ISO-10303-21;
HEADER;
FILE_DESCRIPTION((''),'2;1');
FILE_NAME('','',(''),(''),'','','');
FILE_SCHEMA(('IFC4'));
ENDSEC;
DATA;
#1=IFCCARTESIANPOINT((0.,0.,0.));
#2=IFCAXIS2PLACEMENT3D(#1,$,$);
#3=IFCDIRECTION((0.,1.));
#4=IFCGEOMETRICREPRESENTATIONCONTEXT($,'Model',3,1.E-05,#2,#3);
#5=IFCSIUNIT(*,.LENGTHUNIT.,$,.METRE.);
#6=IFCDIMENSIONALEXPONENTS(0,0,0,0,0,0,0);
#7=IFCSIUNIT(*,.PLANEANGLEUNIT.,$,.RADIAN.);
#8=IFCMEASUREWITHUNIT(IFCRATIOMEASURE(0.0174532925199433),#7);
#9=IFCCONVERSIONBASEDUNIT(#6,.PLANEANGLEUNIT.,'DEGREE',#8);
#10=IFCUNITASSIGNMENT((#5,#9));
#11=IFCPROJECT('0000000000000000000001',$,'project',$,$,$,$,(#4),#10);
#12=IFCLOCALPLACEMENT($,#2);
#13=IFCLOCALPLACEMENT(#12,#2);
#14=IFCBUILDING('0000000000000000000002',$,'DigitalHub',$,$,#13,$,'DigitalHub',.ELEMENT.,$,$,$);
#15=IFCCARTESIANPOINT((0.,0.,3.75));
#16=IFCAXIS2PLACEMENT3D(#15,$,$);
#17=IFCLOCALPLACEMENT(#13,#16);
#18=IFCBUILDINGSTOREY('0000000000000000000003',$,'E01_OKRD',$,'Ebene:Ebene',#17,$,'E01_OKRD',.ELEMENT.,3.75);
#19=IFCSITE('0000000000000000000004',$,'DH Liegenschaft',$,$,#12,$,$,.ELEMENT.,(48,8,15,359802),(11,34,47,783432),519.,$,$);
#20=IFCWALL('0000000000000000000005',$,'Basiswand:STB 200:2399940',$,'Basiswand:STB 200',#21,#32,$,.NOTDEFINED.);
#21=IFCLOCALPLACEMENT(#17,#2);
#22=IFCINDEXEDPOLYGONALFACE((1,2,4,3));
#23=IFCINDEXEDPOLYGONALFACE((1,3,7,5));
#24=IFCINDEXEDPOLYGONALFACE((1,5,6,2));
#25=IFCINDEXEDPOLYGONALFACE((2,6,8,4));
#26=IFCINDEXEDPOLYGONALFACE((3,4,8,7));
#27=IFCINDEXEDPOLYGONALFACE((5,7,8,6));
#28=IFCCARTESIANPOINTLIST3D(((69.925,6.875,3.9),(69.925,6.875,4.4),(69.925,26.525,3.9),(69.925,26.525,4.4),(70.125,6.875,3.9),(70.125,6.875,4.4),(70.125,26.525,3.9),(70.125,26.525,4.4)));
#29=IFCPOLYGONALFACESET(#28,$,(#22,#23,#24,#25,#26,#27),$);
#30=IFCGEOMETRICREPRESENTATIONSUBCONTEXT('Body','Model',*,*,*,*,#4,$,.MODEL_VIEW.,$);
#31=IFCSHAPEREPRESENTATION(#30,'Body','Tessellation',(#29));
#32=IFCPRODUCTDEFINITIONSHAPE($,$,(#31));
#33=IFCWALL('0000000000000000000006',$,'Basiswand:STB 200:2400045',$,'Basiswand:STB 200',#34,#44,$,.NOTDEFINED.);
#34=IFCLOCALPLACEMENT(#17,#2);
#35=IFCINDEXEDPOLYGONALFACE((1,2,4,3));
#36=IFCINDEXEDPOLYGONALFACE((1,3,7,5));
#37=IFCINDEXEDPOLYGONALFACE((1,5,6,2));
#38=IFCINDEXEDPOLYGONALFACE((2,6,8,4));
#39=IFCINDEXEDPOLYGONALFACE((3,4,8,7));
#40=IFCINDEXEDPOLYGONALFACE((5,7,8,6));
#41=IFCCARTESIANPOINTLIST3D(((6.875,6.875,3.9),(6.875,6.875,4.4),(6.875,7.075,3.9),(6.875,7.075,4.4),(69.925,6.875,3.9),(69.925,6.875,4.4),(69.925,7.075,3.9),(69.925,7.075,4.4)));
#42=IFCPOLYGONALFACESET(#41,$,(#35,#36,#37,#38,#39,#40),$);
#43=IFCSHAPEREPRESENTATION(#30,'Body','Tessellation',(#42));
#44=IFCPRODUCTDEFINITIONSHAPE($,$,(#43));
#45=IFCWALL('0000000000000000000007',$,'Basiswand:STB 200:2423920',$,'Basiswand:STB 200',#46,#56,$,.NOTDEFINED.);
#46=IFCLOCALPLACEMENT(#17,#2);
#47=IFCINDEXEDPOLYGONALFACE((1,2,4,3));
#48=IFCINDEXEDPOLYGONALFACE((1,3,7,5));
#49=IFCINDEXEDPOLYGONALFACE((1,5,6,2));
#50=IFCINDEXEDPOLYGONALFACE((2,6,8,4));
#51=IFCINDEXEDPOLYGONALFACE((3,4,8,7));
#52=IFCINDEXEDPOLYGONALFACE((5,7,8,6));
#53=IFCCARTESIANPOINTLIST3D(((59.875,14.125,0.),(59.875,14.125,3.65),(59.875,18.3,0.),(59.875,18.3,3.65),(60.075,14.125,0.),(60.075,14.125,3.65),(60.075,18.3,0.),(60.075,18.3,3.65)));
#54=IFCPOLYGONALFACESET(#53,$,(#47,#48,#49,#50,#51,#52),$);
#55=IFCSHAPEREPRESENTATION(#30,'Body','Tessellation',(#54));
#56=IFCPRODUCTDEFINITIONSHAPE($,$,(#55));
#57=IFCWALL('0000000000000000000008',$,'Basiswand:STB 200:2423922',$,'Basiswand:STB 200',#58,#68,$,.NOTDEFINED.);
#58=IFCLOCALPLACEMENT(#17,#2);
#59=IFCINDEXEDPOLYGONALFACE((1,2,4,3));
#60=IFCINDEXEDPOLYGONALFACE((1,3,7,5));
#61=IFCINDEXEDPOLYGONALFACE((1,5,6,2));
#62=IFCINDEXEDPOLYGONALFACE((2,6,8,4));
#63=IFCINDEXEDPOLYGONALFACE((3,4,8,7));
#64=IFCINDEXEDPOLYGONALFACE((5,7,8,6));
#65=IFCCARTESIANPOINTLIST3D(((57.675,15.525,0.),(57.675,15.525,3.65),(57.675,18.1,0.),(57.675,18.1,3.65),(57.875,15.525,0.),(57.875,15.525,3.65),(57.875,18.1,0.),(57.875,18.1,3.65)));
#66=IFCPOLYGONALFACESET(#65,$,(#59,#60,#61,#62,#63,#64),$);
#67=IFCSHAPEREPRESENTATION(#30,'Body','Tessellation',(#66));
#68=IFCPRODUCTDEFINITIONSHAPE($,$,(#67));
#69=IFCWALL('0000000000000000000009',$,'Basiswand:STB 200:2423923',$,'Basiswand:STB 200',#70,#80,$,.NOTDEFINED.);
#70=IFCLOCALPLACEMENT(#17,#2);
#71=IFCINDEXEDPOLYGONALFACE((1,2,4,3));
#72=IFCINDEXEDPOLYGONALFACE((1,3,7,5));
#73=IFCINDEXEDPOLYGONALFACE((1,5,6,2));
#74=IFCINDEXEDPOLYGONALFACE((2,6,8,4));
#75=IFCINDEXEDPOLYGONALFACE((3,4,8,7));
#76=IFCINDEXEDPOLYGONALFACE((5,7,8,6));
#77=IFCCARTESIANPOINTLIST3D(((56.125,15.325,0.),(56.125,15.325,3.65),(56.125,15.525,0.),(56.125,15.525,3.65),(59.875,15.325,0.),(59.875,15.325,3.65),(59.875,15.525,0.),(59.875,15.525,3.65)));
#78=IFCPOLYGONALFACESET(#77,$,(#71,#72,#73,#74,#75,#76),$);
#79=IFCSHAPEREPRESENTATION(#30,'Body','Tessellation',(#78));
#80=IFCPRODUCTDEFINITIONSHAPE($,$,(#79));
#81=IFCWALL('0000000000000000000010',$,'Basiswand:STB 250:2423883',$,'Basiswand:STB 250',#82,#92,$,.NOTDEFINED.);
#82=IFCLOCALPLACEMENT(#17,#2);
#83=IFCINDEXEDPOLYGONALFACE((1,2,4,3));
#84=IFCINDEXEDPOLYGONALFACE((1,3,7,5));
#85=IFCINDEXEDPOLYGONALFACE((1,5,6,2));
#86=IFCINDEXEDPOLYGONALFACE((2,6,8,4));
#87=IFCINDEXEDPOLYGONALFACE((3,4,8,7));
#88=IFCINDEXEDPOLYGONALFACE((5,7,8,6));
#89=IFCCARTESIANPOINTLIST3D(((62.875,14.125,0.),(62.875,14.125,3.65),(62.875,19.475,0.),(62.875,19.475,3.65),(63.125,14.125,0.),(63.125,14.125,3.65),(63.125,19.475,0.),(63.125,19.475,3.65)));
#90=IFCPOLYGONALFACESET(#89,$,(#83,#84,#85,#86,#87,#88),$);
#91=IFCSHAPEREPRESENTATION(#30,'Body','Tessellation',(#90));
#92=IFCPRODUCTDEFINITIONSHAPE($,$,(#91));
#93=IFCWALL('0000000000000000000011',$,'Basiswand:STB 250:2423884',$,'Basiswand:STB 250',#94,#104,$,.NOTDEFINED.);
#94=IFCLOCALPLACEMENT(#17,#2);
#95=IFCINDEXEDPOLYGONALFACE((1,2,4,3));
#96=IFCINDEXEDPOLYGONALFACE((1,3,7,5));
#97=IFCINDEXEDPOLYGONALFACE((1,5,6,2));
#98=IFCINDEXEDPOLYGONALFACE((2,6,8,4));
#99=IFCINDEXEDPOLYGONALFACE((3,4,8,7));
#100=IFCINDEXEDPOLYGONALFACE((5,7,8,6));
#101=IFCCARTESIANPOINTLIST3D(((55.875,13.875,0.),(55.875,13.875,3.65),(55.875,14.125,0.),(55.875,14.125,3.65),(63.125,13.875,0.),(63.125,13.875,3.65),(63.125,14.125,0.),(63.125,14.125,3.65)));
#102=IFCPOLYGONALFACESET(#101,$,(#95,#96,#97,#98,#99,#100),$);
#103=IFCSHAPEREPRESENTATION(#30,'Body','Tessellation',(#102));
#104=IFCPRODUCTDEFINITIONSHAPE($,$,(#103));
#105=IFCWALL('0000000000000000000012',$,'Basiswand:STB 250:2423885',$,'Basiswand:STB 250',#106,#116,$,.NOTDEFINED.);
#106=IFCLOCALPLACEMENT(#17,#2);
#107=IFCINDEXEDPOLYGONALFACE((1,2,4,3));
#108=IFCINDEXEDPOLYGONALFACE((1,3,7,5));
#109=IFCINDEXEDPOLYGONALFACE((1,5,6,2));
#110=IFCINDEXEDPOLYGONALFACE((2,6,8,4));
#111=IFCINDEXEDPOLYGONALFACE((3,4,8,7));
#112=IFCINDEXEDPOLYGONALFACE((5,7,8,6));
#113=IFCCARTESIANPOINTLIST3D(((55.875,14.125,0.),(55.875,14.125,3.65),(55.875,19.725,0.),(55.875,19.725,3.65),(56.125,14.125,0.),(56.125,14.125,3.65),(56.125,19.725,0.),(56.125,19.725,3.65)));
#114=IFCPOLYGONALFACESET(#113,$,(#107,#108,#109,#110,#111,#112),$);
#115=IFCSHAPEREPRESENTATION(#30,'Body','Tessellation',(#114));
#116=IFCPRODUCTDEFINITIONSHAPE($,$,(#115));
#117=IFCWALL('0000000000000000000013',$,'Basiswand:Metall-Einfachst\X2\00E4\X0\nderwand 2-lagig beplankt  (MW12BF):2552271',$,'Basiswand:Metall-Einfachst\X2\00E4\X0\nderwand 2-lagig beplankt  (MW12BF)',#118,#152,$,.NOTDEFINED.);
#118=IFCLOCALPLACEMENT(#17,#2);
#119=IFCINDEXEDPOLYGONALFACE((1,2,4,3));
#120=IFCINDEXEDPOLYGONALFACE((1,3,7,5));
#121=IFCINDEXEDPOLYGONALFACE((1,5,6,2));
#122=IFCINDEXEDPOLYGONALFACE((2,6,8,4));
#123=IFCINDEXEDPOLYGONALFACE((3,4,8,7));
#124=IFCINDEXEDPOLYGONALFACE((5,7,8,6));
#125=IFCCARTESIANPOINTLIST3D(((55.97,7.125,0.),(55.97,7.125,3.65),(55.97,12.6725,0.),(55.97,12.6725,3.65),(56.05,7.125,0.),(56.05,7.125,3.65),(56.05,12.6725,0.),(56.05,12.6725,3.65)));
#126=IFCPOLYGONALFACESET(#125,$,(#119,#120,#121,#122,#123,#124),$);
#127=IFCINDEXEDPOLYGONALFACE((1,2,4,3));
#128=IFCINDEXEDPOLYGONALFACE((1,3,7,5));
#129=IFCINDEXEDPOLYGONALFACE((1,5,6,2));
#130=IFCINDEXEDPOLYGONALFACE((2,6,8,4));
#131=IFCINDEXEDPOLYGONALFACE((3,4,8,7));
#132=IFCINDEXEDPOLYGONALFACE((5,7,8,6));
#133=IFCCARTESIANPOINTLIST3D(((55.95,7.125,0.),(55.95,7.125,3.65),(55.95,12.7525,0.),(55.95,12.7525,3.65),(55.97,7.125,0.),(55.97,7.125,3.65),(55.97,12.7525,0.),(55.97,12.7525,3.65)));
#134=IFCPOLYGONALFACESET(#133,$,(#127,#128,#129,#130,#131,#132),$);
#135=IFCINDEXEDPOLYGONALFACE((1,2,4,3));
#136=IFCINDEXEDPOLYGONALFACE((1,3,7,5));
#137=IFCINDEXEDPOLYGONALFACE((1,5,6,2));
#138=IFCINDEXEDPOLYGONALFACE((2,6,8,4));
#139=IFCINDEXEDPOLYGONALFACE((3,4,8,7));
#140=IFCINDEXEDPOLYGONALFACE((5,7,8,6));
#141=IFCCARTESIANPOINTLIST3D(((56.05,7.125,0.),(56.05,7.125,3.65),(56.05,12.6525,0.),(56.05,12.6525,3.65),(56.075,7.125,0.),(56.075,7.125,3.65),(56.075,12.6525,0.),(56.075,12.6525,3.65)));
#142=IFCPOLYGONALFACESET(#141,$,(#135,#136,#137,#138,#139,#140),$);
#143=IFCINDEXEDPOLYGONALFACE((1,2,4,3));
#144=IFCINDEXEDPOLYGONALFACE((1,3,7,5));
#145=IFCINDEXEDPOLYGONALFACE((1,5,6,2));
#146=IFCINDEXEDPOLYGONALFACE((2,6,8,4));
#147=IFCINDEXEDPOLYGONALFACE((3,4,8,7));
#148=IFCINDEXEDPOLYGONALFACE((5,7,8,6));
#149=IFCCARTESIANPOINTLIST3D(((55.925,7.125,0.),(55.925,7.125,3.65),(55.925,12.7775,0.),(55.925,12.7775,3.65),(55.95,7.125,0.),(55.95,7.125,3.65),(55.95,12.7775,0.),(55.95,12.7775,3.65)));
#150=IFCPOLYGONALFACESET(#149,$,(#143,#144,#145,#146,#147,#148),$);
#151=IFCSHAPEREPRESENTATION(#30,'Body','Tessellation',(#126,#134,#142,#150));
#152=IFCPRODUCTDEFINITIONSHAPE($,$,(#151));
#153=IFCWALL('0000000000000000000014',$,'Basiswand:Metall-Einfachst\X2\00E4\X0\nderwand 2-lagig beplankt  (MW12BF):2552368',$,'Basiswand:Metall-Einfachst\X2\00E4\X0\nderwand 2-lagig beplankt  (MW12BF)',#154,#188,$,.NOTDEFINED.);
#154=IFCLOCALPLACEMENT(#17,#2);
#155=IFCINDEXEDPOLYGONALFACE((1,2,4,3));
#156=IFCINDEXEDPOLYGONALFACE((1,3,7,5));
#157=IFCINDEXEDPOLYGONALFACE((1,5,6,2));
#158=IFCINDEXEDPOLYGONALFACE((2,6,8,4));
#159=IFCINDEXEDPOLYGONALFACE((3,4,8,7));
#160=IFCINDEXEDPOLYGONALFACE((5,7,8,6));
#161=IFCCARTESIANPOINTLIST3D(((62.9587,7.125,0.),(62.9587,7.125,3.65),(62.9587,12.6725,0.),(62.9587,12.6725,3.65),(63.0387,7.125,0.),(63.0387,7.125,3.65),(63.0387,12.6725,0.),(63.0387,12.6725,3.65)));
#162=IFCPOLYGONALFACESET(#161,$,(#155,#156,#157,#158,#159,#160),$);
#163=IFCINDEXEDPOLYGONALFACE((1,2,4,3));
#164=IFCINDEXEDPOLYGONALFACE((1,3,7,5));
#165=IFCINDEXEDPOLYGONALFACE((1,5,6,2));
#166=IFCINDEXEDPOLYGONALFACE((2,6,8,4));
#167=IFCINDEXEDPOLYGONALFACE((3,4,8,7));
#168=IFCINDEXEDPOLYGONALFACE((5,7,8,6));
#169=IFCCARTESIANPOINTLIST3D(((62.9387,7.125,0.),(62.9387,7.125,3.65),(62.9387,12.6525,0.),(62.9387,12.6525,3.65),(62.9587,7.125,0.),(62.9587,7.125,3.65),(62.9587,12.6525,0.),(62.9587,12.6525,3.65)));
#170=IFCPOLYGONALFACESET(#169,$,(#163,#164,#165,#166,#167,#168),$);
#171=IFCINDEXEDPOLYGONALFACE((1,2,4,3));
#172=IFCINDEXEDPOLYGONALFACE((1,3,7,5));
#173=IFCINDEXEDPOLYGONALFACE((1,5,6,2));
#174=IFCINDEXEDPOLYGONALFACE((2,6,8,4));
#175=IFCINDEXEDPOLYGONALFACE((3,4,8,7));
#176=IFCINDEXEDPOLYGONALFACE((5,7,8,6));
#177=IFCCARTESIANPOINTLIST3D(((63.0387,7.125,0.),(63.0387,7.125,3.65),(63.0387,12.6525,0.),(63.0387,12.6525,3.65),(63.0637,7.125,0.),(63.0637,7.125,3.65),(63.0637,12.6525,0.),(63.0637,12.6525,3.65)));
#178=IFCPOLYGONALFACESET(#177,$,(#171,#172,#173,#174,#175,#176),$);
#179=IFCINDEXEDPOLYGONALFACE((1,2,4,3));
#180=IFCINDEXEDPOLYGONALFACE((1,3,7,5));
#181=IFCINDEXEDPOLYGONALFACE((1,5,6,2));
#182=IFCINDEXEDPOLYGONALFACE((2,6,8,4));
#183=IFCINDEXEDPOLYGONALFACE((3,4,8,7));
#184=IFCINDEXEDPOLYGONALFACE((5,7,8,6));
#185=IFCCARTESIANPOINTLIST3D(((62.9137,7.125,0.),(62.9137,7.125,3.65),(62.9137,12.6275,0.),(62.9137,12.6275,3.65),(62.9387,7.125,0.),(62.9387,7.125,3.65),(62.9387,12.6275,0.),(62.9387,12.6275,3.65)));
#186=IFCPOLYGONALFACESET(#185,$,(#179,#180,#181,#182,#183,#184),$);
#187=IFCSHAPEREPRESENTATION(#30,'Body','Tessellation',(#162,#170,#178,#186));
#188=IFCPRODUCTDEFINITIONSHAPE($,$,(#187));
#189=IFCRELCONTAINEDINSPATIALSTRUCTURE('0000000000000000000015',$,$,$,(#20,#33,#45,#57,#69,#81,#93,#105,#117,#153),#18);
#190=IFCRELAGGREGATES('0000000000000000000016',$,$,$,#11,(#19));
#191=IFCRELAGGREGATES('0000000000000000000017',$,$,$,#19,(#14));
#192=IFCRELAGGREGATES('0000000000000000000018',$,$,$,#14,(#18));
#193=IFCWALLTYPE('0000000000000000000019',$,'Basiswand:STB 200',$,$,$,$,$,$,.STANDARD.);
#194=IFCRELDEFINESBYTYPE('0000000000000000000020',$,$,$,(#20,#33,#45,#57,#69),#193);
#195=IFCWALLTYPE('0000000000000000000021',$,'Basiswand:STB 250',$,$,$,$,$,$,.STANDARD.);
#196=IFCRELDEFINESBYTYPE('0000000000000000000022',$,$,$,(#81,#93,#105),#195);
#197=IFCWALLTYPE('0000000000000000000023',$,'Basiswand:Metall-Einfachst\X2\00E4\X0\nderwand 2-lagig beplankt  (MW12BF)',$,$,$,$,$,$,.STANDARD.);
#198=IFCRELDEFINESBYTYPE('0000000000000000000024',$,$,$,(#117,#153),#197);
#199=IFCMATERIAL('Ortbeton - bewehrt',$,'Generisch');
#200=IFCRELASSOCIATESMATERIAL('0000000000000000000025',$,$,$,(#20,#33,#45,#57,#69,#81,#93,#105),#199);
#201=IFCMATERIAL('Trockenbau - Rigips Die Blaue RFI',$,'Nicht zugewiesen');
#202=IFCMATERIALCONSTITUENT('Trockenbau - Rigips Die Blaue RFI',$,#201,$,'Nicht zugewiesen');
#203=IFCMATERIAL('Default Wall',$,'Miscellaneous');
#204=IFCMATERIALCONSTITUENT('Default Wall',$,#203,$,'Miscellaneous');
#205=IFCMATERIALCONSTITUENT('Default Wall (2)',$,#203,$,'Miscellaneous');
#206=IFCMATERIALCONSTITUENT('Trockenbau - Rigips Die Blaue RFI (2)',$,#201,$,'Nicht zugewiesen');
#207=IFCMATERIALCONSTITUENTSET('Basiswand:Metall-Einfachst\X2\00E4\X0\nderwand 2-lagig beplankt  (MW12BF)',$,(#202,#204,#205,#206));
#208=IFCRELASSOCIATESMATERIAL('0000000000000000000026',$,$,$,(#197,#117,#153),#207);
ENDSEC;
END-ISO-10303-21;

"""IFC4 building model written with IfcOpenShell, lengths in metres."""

from ifc_helpers import new_model, entity, si_unit, converted_unit, direction, frame, origin, place, context, subcontext, project, spatial, indexed_curve, outline, extrude, material, constituent, constituent_set, type_object, element, save


model = new_model("IFC4")

# Units and contexts
model_context = context("Model", 3, precision=1e-05, world=origin(), true_north=direction((0.0, 1.0)))
body_context = subcontext(model_context, "Body", "Model", "MODEL_VIEW")
ifc_project = project(units=[si_unit("LENGTHUNIT", "METRE"), converted_unit("PLANEANGLEUNIT", "DEGREE", entity("IfcRatioMeasure", 0.0174532925199433), si_unit("PLANEANGLEUNIT", "RADIAN"), dimensions=[0, 0, 0, 0, 0, 0, 0])], contexts=[model_context])

# Site, building, storey
site_placement = place(None, frame((0.0, 0.0, 0.0)))
site = spatial("IfcSite", under=ifc_project, at=site_placement, Name="DH Liegenschaft", CompositionType="ELEMENT", RefLatitude=(48, 8, 15, 359802), RefLongitude=(11, 34, 47, 783432), RefElevation=519.0)
building_placement = place(site_placement, origin())
building = spatial("IfcBuilding", under=site, at=building_placement, Name="DigitalHub", LongName="DigitalHub", CompositionType="ELEMENT")
storey_placement = place(building_placement, frame((0.0, 0.0, 3.75)))
storey = spatial("IfcBuildingStorey", under=building, at=storey_placement, Name="E01_OKRD", ObjectType="Ebene:Ebene", LongName="E01_OKRD", CompositionType="ELEMENT", Elevation=3.75)

# Walls
ifc_material_1 = material(Name="Ortbeton - bewehrt", Category="Generisch")
wall_type_1 = type_object("IfcWallType", Name="Basiswand:STB 200", PredefinedType="STANDARD")
wall_1_placement = place(storey_placement, frame((70.025, 26.525, 3.9), z_axis=(0.0, 0.0, 1.0), x_axis=(0.0, -1.0, 0.0)))
element("IfcWall", 1, at=wall_1_placement, inside=storey, type_object=wall_type_1, material=ifc_material_1, Name="Basiswand:STB 200:2399940", ObjectType="Basiswand:STB 200", PredefinedType="NOTDEFINED", context=body_context, shape_type="SweptSolid", body=[
    extrude(outline(indexed_curve([(19.65, 0.1), (0.0, 0.1), (0.0, -0.1), (19.65, -0.1), (19.65, 0.1)], self_intersect=False)), origin(), (0.0, 0.0, 1.0), 0.5),
])
wall_2_placement = place(storey_placement, frame((69.925, 6.975, 3.9), z_axis=(0.0, 0.0, 1.0), x_axis=(-1.0, 0.0, 0.0)))
element("IfcWall", 2, at=wall_2_placement, inside=storey, type_object=wall_type_1, material=ifc_material_1, Name="Basiswand:STB 200:2400045", ObjectType="Basiswand:STB 200", PredefinedType="NOTDEFINED", context=body_context, shape_type="SweptSolid", body=[
    extrude(outline(indexed_curve([(63.05, 0.1), (0.0, 0.1), (0.0, -0.1), (63.05, -0.1), (63.05, 0.1)], self_intersect=False)), origin(), (0.0, 0.0, 1.0), 0.5),
])
wall_3_placement = place(storey_placement, frame((59.975, 14.125, 0.0), z_axis=(0.0, 0.0, 1.0), x_axis=(0.0, 1.0, 0.0)))
element("IfcWall", 3, at=wall_3_placement, inside=storey, type_object=wall_type_1, material=ifc_material_1, Name="Basiswand:STB 200:2423920", ObjectType="Basiswand:STB 200", PredefinedType="NOTDEFINED", context=body_context, shape_type="SweptSolid", body=[
    extrude(outline(indexed_curve([(4.175, 0.1), (0.0, 0.1), (0.0, -0.1), (4.175, -0.1), (4.175, 0.1)], self_intersect=False)), origin(), (0.0, 0.0, 1.0), 3.65),
])
wall_4_placement = place(storey_placement, frame((57.775, 18.1, 0.0), z_axis=(0.0, 0.0, 1.0), x_axis=(0.0, -1.0, 0.0)))
element("IfcWall", 4, at=wall_4_placement, inside=storey, type_object=wall_type_1, material=ifc_material_1, Name="Basiswand:STB 200:2423922", ObjectType="Basiswand:STB 200", PredefinedType="NOTDEFINED", context=body_context, shape_type="SweptSolid", body=[
    extrude(outline(indexed_curve([(2.575, 0.1), (0.0, 0.1), (0.0, -0.1), (2.575, -0.1), (2.575, 0.1)], self_intersect=False)), origin(), (0.0, 0.0, 1.0), 3.65),
])
wall_5_placement = place(storey_placement, frame((56.125, 15.425, 0.0)))
element("IfcWall", 5, at=wall_5_placement, inside=storey, type_object=wall_type_1, material=ifc_material_1, Name="Basiswand:STB 200:2423923", ObjectType="Basiswand:STB 200", PredefinedType="NOTDEFINED", context=body_context, shape_type="SweptSolid", body=[
    extrude(outline(indexed_curve([(3.75, 0.1), (0.0, 0.1), (0.0, -0.1), (3.75, -0.1), (3.75, 0.1)], self_intersect=False)), origin(), (0.0, 0.0, 1.0), 3.65),
])
wall_type_2 = type_object("IfcWallType", Name="Basiswand:STB 250", PredefinedType="STANDARD")
wall_6_placement = place(storey_placement, frame((63.0, 14.125, 0.0), z_axis=(0.0, 0.0, 1.0), x_axis=(0.0, 1.0, 0.0)))
element("IfcWall", 6, at=wall_6_placement, inside=storey, type_object=wall_type_2, material=ifc_material_1, Name="Basiswand:STB 250:2423883", ObjectType="Basiswand:STB 250", PredefinedType="NOTDEFINED", context=body_context, shape_type="SweptSolid", body=[
    extrude(outline(indexed_curve([(5.35, 0.125), (0.0, 0.125), (0.0, -0.125), (5.35, -0.125), (5.35, 0.125)], self_intersect=False)), origin(), (0.0, 0.0, 1.0), 3.65),
])
wall_7_placement = place(storey_placement, frame((63.125, 14.0, 0.0), z_axis=(0.0, 0.0, 1.0), x_axis=(-1.0, 0.0, 0.0)))
element("IfcWall", 7, at=wall_7_placement, inside=storey, type_object=wall_type_2, material=ifc_material_1, Name="Basiswand:STB 250:2423884", ObjectType="Basiswand:STB 250", PredefinedType="NOTDEFINED", context=body_context, shape_type="SweptSolid", body=[
    extrude(outline(indexed_curve([(7.25, 0.125), (0.0, 0.125), (0.0, -0.125), (7.25, -0.125), (7.25, 0.125)], self_intersect=False)), origin(), (0.0, 0.0, 1.0), 3.65),
])
wall_8_placement = place(storey_placement, frame((56.0, 14.125, 0.0), z_axis=(0.0, 0.0, 1.0), x_axis=(0.0, 1.0, 0.0)))
element("IfcWall", 8, at=wall_8_placement, inside=storey, type_object=wall_type_2, material=ifc_material_1, Name="Basiswand:STB 250:2423885", ObjectType="Basiswand:STB 250", PredefinedType="NOTDEFINED", context=body_context, shape_type="SweptSolid", body=[
    extrude(outline(indexed_curve([(5.6, 0.125), (0.0, 0.125), (0.0, -0.125), (5.6, -0.125), (5.6, 0.125)], self_intersect=False)), origin(), (0.0, 0.0, 1.0), 3.65),
])

# Shared definitions
ifc_material_2 = material(Name="Trockenbau - Rigips Die Blaue RFI", Category="Nicht zugewiesen")
ifc_constituent_1 = constituent(ifc_material_2, Name="Trockenbau - Rigips Die Blaue RFI", Category="Nicht zugewiesen")
ifc_material_3 = material(Name="Default Wall", Category="Miscellaneous")
ifc_constituent_2 = constituent(ifc_material_3, Name="Default Wall", Category="Miscellaneous")
ifc_constituent_3 = constituent(ifc_material_3, Name="Default Wall (2)", Category="Miscellaneous")
ifc_constituent_4 = constituent(ifc_material_2, Name="Trockenbau - Rigips Die Blaue RFI (2)", Category="Nicht zugewiesen")
ifc_constituent_set_1 = constituent_set(constituents=[ifc_constituent_1, ifc_constituent_2, ifc_constituent_3, ifc_constituent_4], Name="Basiswand:Metall-Einfachständerwand 2-lagig beplankt  (MW12BF)")
wall_type_3 = type_object("IfcWallType", Name="Basiswand:Metall-Einfachständerwand 2-lagig beplankt  (MW12BF)", PredefinedType="STANDARD", material=ifc_constituent_set_1)

# Walls
wall_9_placement = place(storey_placement, frame((56.0, 12.6275, 0.0), z_axis=(0.0, 0.0, 1.0), x_axis=(0.0, -1.0, 0.0)))
element("IfcWall", 9, at=wall_9_placement, inside=storey, type_object=wall_type_3, material=ifc_constituent_set_1, Name="Basiswand:Metall-Einfachständerwand 2-lagig beplankt  (MW12BF):2552271", ObjectType="Basiswand:Metall-Einfachständerwand 2-lagig beplankt  (MW12BF)", PredefinedType="NOTDEFINED", context=body_context, shape_type="SweptSolid", body=[
    extrude(outline(indexed_curve([(-2.7738, -0.04), (2.7738, -0.04), (2.7738, 0.04), (-2.7738, 0.04), (-2.7738, -0.04)], self_intersect=False)), frame((2.7288, 0.01, 0.0)), (0.0, 0.0, 1.0), 3.65),
    extrude(outline(indexed_curve([(-2.8138, -0.01), (2.8138, -0.01), (2.8138, 0.01), (-2.8138, 0.01), (-2.8138, -0.01)], self_intersect=False)), frame((2.6888, -0.04, 0.0)), (0.0, 0.0, 1.0), 3.65),
    extrude(outline(indexed_curve([(-0.0125, -2.7638), (0.0125, -2.7638), (0.0125, 2.7638), (-0.0125, 2.7638), (-0.0125, -2.7638)], self_intersect=False)), frame((2.7388, 0.0625, 0.0), z_axis=(0.0, 0.0, 1.0), x_axis=(0.0, -1.0, 0.0)), (0.0, 0.0, 1.0), 3.65),
    extrude(outline(indexed_curve([(-0.0125, -2.8263), (0.0125, -2.8263), (0.0125, 2.8263), (-0.0125, 2.8263), (-0.0125, -2.8263)], self_intersect=False)), frame((2.6763, -0.0625, 0.0), z_axis=(0.0, 0.0, 1.0), x_axis=(0.0, 1.0, 0.0)), (0.0, 0.0, 1.0), 3.65),
])
wall_10_placement = place(storey_placement, frame((62.9887, 12.6275, 0.0), z_axis=(0.0, 0.0, 1.0), x_axis=(0.0, -1.0, 0.0)))
element("IfcWall", 10, at=wall_10_placement, inside=storey, type_object=wall_type_3, material=ifc_constituent_set_1, Name="Basiswand:Metall-Einfachständerwand 2-lagig beplankt  (MW12BF):2552368", ObjectType="Basiswand:Metall-Einfachständerwand 2-lagig beplankt  (MW12BF)", PredefinedType="NOTDEFINED", context=body_context, shape_type="SweptSolid", body=[
    extrude(outline(indexed_curve([(-2.7738, -0.04), (2.7738, -0.04), (2.7738, 0.04), (-2.7738, 0.04), (-2.7738, -0.04)], self_intersect=False)), frame((2.7288, 0.01, 0.0)), (0.0, 0.0, 1.0), 3.65),
    extrude(outline(indexed_curve([(-2.7638, -0.01), (2.7638, -0.01), (2.7638, 0.01), (-2.7638, 0.01), (-2.7638, -0.01)], self_intersect=False)), frame((2.7388, -0.04, 0.0)), (0.0, 0.0, 1.0), 3.65),
    extrude(outline(indexed_curve([(-0.0125, -2.7638), (0.0125, -2.7638), (0.0125, 2.7638), (-0.0125, 2.7638), (-0.0125, -2.7638)], self_intersect=False)), frame((2.7388, 0.0625, 0.0), z_axis=(0.0, 0.0, 1.0), x_axis=(0.0, -1.0, 0.0)), (0.0, 0.0, 1.0), 3.65),
    extrude(outline(indexed_curve([(-0.0125, -2.7513), (0.0125, -2.7513), (0.0125, 2.7513), (-0.0125, 2.7513), (-0.0125, -2.7513)], self_intersect=False)), frame((2.7513, -0.0625, 0.0), z_axis=(0.0, 0.0, 1.0), x_axis=(0.0, 1.0, 0.0)), (0.0, 0.0, 1.0), 3.65),
])

save(model, "model.ifc")
